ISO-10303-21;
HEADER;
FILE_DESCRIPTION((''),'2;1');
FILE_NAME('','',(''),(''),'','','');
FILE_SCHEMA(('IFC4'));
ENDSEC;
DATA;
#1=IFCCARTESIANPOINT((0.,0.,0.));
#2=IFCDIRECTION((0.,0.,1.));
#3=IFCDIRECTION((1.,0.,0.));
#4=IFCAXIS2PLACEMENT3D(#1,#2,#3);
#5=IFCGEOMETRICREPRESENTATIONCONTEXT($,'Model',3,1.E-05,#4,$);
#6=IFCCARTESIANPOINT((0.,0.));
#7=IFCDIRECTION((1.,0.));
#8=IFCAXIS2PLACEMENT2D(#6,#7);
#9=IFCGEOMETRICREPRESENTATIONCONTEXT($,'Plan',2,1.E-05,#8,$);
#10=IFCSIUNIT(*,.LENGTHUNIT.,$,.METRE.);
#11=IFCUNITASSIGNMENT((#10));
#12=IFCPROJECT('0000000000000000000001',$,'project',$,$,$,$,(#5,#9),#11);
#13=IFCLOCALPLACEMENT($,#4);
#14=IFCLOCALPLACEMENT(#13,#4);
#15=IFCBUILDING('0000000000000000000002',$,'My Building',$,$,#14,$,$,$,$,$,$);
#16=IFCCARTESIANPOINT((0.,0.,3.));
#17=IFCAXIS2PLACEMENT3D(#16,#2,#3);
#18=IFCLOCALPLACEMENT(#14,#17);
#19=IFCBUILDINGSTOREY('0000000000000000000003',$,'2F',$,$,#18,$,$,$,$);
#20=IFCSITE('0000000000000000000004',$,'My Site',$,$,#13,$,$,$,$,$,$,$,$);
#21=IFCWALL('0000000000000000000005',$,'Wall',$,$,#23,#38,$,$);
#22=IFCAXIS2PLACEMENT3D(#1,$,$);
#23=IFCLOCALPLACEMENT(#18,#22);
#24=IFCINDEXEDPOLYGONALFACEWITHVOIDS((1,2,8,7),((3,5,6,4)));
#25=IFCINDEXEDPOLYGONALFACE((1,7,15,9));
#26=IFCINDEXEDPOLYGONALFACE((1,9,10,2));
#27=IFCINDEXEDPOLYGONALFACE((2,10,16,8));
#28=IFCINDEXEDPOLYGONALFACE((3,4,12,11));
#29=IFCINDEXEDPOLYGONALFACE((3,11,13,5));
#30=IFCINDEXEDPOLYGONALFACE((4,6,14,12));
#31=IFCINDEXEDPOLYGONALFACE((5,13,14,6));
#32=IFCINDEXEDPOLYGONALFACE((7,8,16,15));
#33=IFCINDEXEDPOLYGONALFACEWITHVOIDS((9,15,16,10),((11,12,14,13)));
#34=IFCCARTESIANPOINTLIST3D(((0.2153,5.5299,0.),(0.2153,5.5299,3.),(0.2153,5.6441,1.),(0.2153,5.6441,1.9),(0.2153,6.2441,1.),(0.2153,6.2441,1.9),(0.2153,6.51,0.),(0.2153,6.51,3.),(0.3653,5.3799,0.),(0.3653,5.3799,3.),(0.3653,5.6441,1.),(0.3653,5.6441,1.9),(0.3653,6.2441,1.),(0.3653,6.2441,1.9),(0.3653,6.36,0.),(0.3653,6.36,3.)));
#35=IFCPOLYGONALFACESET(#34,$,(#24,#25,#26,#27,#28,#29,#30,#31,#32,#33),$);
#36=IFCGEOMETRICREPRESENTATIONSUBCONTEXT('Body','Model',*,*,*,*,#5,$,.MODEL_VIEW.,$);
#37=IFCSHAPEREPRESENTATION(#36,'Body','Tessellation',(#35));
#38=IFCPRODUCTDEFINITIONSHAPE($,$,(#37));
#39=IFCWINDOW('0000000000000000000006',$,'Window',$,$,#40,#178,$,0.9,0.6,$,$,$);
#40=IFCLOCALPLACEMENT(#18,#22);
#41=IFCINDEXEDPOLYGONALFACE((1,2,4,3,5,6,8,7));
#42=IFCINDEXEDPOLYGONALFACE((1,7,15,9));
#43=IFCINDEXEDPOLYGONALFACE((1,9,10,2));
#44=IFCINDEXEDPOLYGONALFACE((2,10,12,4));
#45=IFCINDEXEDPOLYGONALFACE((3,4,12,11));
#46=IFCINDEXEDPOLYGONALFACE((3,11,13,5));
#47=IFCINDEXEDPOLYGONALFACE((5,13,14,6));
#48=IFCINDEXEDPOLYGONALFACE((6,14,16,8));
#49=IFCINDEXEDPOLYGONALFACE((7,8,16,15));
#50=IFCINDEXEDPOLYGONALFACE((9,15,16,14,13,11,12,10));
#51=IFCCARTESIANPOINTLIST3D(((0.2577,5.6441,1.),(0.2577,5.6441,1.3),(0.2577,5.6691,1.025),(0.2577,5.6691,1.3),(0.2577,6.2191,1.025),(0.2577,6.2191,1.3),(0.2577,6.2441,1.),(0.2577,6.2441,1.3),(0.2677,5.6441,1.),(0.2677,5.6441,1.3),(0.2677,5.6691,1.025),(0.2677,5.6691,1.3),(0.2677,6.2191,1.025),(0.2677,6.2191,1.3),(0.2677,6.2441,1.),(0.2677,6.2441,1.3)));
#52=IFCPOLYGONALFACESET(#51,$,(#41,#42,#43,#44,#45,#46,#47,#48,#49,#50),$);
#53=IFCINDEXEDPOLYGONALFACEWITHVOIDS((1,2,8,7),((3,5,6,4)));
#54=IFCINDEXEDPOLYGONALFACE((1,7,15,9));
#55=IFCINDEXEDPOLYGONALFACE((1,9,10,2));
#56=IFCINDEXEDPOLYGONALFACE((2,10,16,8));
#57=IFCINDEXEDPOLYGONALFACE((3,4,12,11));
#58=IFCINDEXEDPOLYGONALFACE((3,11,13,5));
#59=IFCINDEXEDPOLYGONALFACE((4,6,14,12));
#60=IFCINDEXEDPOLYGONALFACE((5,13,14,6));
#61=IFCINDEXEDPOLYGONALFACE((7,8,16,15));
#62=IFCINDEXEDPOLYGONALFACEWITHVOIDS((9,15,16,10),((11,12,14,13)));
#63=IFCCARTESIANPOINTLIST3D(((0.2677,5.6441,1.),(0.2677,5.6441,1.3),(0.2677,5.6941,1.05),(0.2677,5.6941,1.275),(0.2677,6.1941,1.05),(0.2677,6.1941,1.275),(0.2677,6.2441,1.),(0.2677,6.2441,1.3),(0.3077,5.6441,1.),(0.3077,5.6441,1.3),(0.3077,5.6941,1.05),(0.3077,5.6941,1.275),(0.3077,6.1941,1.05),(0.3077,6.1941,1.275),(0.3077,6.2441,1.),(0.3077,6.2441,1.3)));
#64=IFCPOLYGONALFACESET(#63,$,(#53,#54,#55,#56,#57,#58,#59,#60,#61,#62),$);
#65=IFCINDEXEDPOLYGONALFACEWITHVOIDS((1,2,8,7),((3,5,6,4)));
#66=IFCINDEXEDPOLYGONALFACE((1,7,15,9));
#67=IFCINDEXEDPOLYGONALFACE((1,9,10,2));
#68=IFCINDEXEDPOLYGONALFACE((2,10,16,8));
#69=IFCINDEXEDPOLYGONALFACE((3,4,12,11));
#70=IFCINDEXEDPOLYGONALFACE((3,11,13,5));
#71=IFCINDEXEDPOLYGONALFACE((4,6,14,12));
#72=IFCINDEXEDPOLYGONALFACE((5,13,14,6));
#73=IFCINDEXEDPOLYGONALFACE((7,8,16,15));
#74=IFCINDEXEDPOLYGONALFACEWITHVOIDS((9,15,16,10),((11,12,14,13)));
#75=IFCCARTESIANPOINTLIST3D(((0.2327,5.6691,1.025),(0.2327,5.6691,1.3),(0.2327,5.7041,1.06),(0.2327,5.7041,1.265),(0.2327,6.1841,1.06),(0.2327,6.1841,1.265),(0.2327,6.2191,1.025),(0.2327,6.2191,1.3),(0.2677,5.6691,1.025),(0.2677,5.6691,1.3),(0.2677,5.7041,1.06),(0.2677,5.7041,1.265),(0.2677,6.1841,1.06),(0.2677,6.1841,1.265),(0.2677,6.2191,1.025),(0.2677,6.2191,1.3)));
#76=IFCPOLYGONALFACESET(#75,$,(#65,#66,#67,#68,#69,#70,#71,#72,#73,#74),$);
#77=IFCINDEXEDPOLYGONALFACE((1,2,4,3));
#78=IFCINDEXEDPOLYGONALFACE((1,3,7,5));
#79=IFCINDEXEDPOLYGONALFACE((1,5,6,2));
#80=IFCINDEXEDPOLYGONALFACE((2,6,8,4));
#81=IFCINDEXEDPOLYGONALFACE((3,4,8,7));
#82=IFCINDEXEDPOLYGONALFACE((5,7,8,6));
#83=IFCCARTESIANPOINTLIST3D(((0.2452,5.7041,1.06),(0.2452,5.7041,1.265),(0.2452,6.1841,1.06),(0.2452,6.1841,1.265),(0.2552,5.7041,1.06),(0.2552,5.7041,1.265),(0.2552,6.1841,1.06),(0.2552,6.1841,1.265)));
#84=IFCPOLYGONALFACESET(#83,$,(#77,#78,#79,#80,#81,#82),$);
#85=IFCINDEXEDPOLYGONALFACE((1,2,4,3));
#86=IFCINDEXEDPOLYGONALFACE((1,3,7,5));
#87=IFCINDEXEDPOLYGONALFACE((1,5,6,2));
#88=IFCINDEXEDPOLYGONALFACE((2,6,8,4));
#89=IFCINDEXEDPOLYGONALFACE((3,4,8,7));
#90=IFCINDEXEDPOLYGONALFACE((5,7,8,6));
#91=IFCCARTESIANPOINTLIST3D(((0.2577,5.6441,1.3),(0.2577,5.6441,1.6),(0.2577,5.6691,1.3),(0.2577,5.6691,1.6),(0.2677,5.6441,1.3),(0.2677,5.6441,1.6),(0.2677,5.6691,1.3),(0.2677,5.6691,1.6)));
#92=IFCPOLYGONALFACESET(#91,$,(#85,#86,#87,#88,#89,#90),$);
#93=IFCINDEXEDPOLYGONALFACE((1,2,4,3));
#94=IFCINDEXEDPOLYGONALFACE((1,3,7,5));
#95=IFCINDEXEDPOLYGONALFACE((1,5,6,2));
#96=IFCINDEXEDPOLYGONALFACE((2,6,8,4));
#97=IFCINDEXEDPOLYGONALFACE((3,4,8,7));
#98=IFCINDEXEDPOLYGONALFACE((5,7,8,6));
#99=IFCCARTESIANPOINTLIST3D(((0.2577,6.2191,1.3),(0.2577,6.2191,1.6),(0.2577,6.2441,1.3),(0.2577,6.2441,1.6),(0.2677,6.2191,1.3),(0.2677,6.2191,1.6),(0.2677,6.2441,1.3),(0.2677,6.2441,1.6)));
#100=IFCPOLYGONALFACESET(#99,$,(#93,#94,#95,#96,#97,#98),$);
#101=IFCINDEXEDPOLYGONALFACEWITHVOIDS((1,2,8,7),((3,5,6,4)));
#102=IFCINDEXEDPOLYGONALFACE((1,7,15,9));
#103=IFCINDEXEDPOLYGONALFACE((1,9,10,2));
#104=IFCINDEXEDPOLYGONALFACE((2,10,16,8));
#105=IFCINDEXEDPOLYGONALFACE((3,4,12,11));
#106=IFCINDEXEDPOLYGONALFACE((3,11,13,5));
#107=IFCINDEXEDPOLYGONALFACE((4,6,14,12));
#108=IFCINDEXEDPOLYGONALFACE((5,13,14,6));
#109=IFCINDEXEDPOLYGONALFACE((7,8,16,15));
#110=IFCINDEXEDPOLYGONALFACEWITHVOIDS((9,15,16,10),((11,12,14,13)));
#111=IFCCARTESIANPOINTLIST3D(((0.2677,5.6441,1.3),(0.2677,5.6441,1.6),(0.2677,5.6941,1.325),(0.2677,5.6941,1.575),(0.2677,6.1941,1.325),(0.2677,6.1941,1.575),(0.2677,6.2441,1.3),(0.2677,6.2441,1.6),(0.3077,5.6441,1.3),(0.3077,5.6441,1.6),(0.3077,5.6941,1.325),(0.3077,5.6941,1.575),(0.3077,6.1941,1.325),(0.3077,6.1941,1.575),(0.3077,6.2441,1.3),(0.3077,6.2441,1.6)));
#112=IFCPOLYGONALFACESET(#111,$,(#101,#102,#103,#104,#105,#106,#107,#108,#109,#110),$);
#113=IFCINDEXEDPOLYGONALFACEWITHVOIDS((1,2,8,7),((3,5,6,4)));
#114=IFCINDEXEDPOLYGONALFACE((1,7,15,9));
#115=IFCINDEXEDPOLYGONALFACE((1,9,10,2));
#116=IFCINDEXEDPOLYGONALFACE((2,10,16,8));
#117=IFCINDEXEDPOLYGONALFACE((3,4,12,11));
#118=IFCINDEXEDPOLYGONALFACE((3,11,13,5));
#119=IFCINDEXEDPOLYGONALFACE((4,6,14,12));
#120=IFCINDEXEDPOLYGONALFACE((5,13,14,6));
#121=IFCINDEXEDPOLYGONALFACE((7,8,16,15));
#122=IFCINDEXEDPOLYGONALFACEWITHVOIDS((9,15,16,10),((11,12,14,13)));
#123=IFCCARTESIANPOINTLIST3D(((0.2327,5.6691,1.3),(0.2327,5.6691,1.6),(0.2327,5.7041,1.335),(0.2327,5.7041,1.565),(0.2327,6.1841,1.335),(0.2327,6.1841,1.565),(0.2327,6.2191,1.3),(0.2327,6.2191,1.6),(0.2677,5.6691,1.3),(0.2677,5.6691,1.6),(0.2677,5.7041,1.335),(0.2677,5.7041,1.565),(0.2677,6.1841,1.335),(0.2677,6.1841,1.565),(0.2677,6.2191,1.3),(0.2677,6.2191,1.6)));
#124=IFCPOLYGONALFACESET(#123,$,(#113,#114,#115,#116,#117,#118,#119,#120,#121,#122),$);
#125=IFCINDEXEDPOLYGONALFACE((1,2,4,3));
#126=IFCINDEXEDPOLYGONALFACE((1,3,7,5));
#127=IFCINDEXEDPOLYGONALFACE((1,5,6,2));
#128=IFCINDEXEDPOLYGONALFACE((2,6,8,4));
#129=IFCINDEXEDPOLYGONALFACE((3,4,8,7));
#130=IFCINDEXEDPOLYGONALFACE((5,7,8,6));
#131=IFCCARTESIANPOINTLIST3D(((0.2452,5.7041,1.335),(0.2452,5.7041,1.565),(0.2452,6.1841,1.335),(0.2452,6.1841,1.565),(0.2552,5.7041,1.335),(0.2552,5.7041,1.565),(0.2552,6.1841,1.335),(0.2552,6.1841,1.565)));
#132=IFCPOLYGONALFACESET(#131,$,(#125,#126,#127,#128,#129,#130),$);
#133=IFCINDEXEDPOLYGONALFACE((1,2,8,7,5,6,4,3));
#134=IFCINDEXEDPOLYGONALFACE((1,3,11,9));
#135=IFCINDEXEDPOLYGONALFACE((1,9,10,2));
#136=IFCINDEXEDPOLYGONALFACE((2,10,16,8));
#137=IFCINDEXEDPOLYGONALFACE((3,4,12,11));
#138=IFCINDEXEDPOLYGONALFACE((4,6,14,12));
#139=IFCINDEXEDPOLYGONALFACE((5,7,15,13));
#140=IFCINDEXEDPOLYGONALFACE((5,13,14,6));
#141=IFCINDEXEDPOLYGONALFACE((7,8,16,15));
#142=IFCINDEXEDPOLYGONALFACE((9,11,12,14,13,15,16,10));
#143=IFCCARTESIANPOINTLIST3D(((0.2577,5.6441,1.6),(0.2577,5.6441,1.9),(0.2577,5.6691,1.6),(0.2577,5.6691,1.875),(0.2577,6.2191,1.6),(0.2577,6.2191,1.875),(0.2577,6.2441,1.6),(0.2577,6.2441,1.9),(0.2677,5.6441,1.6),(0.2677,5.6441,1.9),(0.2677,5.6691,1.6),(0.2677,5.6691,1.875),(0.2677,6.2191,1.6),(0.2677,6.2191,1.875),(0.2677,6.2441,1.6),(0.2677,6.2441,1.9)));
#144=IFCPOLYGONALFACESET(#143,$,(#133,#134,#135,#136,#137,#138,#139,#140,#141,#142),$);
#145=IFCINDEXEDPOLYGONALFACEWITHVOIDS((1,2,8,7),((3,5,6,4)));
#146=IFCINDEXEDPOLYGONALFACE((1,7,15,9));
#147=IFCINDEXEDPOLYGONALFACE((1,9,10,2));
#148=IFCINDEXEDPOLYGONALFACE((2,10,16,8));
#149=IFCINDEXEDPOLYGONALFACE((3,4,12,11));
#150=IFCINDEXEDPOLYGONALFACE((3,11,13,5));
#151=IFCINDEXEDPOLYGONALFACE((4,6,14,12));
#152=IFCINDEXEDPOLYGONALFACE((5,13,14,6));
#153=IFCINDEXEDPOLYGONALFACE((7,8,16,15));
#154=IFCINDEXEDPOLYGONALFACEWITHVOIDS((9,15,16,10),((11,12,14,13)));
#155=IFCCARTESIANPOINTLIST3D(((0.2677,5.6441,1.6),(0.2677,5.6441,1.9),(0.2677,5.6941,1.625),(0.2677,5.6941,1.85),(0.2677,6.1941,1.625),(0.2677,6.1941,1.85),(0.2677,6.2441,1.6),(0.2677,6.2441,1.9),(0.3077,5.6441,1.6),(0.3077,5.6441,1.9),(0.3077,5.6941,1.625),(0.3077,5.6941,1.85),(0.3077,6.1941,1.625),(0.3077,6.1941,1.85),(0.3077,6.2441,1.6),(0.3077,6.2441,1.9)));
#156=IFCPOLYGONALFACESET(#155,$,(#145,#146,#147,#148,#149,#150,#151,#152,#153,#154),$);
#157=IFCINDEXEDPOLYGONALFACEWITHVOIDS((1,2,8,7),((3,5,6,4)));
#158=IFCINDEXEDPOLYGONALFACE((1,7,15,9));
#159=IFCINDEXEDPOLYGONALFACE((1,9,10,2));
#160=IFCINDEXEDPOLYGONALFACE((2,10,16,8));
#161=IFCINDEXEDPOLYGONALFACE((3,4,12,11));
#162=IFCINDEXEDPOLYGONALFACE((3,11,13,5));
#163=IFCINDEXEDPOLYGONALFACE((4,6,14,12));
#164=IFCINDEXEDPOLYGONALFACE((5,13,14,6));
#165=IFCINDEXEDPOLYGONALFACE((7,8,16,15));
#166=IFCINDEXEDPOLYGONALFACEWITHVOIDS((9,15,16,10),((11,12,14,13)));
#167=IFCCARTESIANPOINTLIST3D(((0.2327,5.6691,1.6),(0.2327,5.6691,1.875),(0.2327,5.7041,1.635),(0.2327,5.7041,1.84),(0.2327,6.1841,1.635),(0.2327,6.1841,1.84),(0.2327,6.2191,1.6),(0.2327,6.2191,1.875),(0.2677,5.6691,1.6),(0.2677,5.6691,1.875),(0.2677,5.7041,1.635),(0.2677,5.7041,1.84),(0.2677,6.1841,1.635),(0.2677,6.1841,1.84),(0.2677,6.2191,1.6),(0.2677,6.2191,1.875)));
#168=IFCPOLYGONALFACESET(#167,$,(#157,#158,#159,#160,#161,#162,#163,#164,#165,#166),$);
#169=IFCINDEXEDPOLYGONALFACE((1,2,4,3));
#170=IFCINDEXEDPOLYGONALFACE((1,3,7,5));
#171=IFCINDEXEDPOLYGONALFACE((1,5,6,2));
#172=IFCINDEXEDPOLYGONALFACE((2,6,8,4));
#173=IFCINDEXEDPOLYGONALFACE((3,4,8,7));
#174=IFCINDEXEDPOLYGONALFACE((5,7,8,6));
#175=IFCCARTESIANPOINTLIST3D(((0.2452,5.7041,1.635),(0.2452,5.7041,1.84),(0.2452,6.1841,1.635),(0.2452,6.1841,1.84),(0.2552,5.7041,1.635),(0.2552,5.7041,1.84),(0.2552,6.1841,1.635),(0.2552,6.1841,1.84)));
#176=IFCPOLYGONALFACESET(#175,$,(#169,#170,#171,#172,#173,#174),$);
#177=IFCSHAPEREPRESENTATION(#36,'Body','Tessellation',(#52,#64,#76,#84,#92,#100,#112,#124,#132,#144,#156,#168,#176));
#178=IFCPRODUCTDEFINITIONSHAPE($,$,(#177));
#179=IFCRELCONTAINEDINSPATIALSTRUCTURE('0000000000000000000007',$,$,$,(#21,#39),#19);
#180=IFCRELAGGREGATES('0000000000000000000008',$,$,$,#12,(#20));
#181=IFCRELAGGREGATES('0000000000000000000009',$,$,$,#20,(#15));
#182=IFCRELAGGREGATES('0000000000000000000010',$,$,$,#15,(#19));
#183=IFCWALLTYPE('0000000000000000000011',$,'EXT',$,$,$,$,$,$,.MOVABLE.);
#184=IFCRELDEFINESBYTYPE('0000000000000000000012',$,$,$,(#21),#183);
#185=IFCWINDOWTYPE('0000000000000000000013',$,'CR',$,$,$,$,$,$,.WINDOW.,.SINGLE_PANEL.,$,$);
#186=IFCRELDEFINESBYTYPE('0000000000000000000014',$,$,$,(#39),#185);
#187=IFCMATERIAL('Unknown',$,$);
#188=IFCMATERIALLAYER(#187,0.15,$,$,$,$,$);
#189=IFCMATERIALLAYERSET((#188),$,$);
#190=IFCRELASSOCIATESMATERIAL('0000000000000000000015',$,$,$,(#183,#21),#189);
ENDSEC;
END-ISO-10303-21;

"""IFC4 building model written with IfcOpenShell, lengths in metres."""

from ifc_helpers import new_model, entity, si_unit, frame, origin_with_axes, origin_2d_with_axis, place, context, subcontext, project, spatial, line, indexed_curve, outline, extrude, shape, source, transform, mapped, material, layer, layer_set, layer_usage, type_object, type_shapes, element, fill, save


model = new_model("IFC4")

# Units and contexts
model_context = context("Model", 3, precision=1e-05, world=origin_with_axes())
plan_context = context("Plan", 2, precision=1e-05, world=origin_2d_with_axis())
body_context_1 = subcontext(model_context, "Body", "Model", "MODEL_VIEW")
body_context_2 = subcontext(plan_context, "Body", "Plan", "PLAN_VIEW")
ifc_project = project(units=[si_unit("LENGTHUNIT", "METRE")], contexts=[model_context, plan_context])

# Site, building, storey
site_placement = place(None, origin_with_axes())
site = spatial("IfcSite", under=ifc_project, at=site_placement, Name="My Site")
building_placement = place(site_placement, origin_with_axes())
building = spatial("IfcBuilding", under=site, at=building_placement, Name="My Building")
storey_placement = place(building_placement, frame((0.0, 0.0, 3.0), z_axis=(0.0, 0.0, 1.0), x_axis=(1.0, 0.0, 0.0)))
storey = spatial("IfcBuildingStorey", under=building, at=storey_placement, Name="2F")

# Shared definitions
ifc_material = material(Name="Unknown")

# Shared definitions
ifc_layer_1 = layer(ifc_material, 0.15)
ifc_layer_set_1 = layer_set([ifc_layer_1])
wall_type_1 = type_object("IfcWallType", Name="EXT", PredefinedType="MOVABLE", material=ifc_layer_set_1)

# Wall, opening, window
ifc_layer_usage_1 = layer_usage(ifc_layer_set_1, "AXIS2", "POSITIVE", -0.15)
wall_1_placement = place(storey_placement, frame((0.2153, 5.5299, 0.0), z_axis=(0.0, 0.0, 1.0), x_axis=(0.0, 1.0, 0.0)))
wall_1 = element("IfcWall", 1, at=wall_1_placement, inside=storey, type_object=wall_type_1, material=ifc_layer_usage_1, Name="Wall", context=body_context_1, shape_type="SweptSolid", body=[
    extrude(outline(indexed_curve([(-0.15, -0.15), (0.0, 0.0), (0.9801, 0.0), (0.8301, -0.15)], segments=[line(1, 2, 3, 4, 1)])), origin_with_axes(), (0.0, 0.0, 1.0), 3.0),
])
placement_1 = place(storey_placement, frame((0.3577, 5.6441, 1.0), z_axis=(0.0, 0.0, 1.0), x_axis=(0.0, 1.0, 0.0)))
opening_1 = element("IfcOpeningElement", 2, at=placement_1, cuts=wall_1, PredefinedType="OPENING", context=body_context_1, shape_type="SweptSolid", body=[
    extrude(outline(indexed_curve([(0.0, 0.0), (0.6, 0.0), (0.6, 0.9), (0.0, 0.9)], segments=[line(1, 2, 3, 4, 1)])), frame((0.0, -0.6, 0.0), z_axis=(0.0, -1.0, 0.0), x_axis=(1.0, 0.0, 0.0)), (0.0, 0.0, -1.0), 1.2),
])
window_type_1 = type_object("IfcWindowType", Name="CR", PartitioningType="SINGLE_PANEL", PredefinedType="WINDOW")
shared_shape_1 = source(origin_with_axes(), body_context_1, "Body", "SweptSolid", [
    extrude(outline(indexed_curve([(0.6, 0.3), (0.6, 0.0), (0.0, 0.0), (0.0, 0.3), (0.025, 0.3), (0.025, 0.025), (0.575, 0.025), (0.575, 0.3)], segments=[line(1, 2, 3, 4, 5, 6, 7, 8, 1)])), frame((0.0, 0.09, 0.0), z_axis=(0.0, -1.0, 0.0), x_axis=(1.0, 0.0, 0.0)), (0.0, 0.0, -1.0), 0.01),
    extrude(outline(indexed_curve([(0.0, 0.0), (0.6, 0.0), (0.6, 0.3), (0.0, 0.3)], segments=[line(1, 2, 3, 4, 1)]), holes=[indexed_curve([(0.05, 0.05), (0.55, 0.05), (0.55, 0.275), (0.05, 0.275)], segments=[line(1, 2, 3, 4, 1)])]), frame((0.0, 0.05, 0.0), z_axis=(0.0, -1.0, 0.0), x_axis=(1.0, 0.0, 0.0)), (0.0, 0.0, -1.0), 0.04),
    extrude(outline(indexed_curve([(0.0, 0.0), (0.55, 0.0), (0.55, 0.275), (0.0, 0.275)], segments=[line(1, 2, 3, 4, 1)]), holes=[indexed_curve([(0.035, 0.035), (0.515, 0.035), (0.515, 0.24), (0.035, 0.24)], segments=[line(1, 2, 3, 4, 1)])]), frame((0.025, 0.09, 0.025), z_axis=(0.0, -1.0, 0.0), x_axis=(1.0, 0.0, 0.0)), (0.0, 0.0, -1.0), 0.035),
    extrude(outline(indexed_curve([(0.035, 0.035), (0.515, 0.035), (0.515, 0.24), (0.035, 0.24)], segments=[line(1, 2, 3, 4, 1)])), frame((0.025, 0.1025, 0.025), z_axis=(0.0, -1.0, 0.0), x_axis=(1.0, 0.0, 0.0)), (0.0, 0.0, -1.0), 0.01),
    extrude(outline(indexed_curve([(0.0, 0.0), (0.0, 0.3), (0.025, 0.3), (0.025, 0.0)], segments=[line(1, 2, 3, 4, 1)])), frame((0.0, 0.09, 0.3), z_axis=(0.0, -1.0, 0.0), x_axis=(1.0, 0.0, 0.0)), (0.0, 0.0, -1.0), 0.01),
    extrude(outline(indexed_curve([(0.6, 0.3), (0.6, 0.0), (0.575, 0.0), (0.575, 0.3)], segments=[line(1, 2, 3, 4, 1)])), frame((0.0, 0.09, 0.3), z_axis=(0.0, -1.0, 0.0), x_axis=(1.0, 0.0, 0.0)), (0.0, 0.0, -1.0), 0.01),
    extrude(outline(indexed_curve([(0.0, 0.0), (0.6, 0.0), (0.6, 0.3), (0.0, 0.3)], segments=[line(1, 2, 3, 4, 1)]), holes=[indexed_curve([(0.05, 0.025), (0.55, 0.025), (0.55, 0.275), (0.05, 0.275)], segments=[line(1, 2, 3, 4, 1)])]), frame((0.0, 0.05, 0.3), z_axis=(0.0, -1.0, 0.0), x_axis=(1.0, 0.0, 0.0)), (0.0, 0.0, -1.0), 0.04),
    extrude(outline(indexed_curve([(0.0, 0.0), (0.55, 0.0), (0.55, 0.3), (0.0, 0.3)], segments=[line(1, 2, 3, 4, 1)]), holes=[indexed_curve([(0.035, 0.035), (0.515, 0.035), (0.515, 0.265), (0.035, 0.265)], segments=[line(1, 2, 3, 4, 1)])]), frame((0.025, 0.09, 0.3), z_axis=(0.0, -1.0, 0.0), x_axis=(1.0, 0.0, 0.0)), (0.0, 0.0, -1.0), 0.035),
    extrude(outline(indexed_curve([(0.035, 0.035), (0.515, 0.035), (0.515, 0.265), (0.035, 0.265)], segments=[line(1, 2, 3, 4, 1)])), frame((0.025, 0.1025, 0.3), z_axis=(0.0, -1.0, 0.0), x_axis=(1.0, 0.0, 0.0)), (0.0, 0.0, -1.0), 0.01),
    extrude(outline(indexed_curve([(0.0, 0.0), (0.0, 0.3), (0.6, 0.3), (0.6, 0.0), (0.575, 0.0), (0.575, 0.275), (0.025, 0.275), (0.025, 0.0)], segments=[line(1, 2, 3, 4, 5, 6, 7, 8, 1)])), frame((0.0, 0.09, 0.6), z_axis=(0.0, -1.0, 0.0), x_axis=(1.0, 0.0, 0.0)), (0.0, 0.0, -1.0), 0.01),
    extrude(outline(indexed_curve([(0.0, 0.0), (0.6, 0.0), (0.6, 0.3), (0.0, 0.3)], segments=[line(1, 2, 3, 4, 1)]), holes=[indexed_curve([(0.05, 0.025), (0.55, 0.025), (0.55, 0.25), (0.05, 0.25)], segments=[line(1, 2, 3, 4, 1)])]), frame((0.0, 0.05, 0.6), z_axis=(0.0, -1.0, 0.0), x_axis=(1.0, 0.0, 0.0)), (0.0, 0.0, -1.0), 0.04),
    extrude(outline(indexed_curve([(0.0, 0.0), (0.55, 0.0), (0.55, 0.275), (0.0, 0.275)], segments=[line(1, 2, 3, 4, 1)]), holes=[indexed_curve([(0.035, 0.035), (0.515, 0.035), (0.515, 0.24), (0.035, 0.24)], segments=[line(1, 2, 3, 4, 1)])]), frame((0.025, 0.09, 0.6), z_axis=(0.0, -1.0, 0.0), x_axis=(1.0, 0.0, 0.0)), (0.0, 0.0, -1.0), 0.035),
    extrude(outline(indexed_curve([(0.035, 0.035), (0.515, 0.035), (0.515, 0.24), (0.035, 0.24)], segments=[line(1, 2, 3, 4, 1)])), frame((0.025, 0.1025, 0.6), z_axis=(0.0, -1.0, 0.0), x_axis=(1.0, 0.0, 0.0)), (0.0, 0.0, -1.0), 0.01),
])
shared_shape_2 = source(origin_with_axes(), body_context_2, "Body", "Curve2D", [
    entity("IfcIndexedPolyCurve", entity("IfcCartesianPointList2D", [[0.05, 0.05], [0.55, 0.05]])),
    entity("IfcIndexedPolyCurve", entity("IfcCartesianPointList2D", [[0.0, 0.1], [0.025, 0.1], [0.025, 0.09], [0.05, 0.09], [0.05, 0.05], [0.0, 0.05]]), [entity("IfcLineIndex", [1, 2, 3, 4, 5, 6, 1])]),
    entity("IfcIndexedPolyCurve", entity("IfcCartesianPointList2D", [[0.6, 0.1], [0.575, 0.1], [0.575, 0.09], [0.55, 0.09], [0.55, 0.05], [0.6, 0.05]]), [entity("IfcLineIndex", [1, 2, 3, 4, 5, 6, 1])]),
    entity("IfcIndexedPolyCurve", entity("IfcCartesianPointList2D", [[0.025, 0.09], [0.06, 0.09], [0.06, 0.125], [0.025, 0.125]]), [entity("IfcLineIndex", [1, 2, 3, 4, 1])]),
    entity("IfcIndexedPolyCurve", entity("IfcCartesianPointList2D", [[0.575, 0.09], [0.54, 0.09], [0.54, 0.125], [0.575, 0.125]]), [entity("IfcLineIndex", [1, 2, 3, 4, 1])]),
    entity("IfcIndexedPolyCurve", entity("IfcCartesianPointList2D", [[0.06, 0.09], [0.54, 0.09]])),
    entity("IfcIndexedPolyCurve", entity("IfcCartesianPointList2D", [[0.06, 0.125], [0.54, 0.125]])),
    entity("IfcIndexedPolyCurve", entity("IfcCartesianPointList2D", [[0.06, 0.1075], [0.54, 0.1075]])),
])
type_shapes(window_type_1, [shared_shape_1, shared_shape_2])
window_1 = element("IfcWindow", 3, at=placement_1, inside=storey, type_object=window_type_1, Name="Window", OverallHeight=0.9, OverallWidth=0.6, shapes=[
    shape(body_context_1, "Body", "MappedRepresentation", [mapped(shared_shape_1, transform((0.0, 0.0, 0.0), x_axis=(1.0, 0.0, 0.0), y_axis=(0.0, 1.0, 0.0), z_axis=(0.0, 0.0, 1.0), scale=1.0))]),
    shape(body_context_2, "Body", "MappedRepresentation", [mapped(shared_shape_2, transform((0.0, 0.0, 0.0), x_axis=(1.0, 0.0, 0.0), y_axis=(0.0, 1.0, 0.0), z_axis=(0.0, 0.0, 1.0), scale=1.0))]),
])
fill(opening_1, window_1)

save(model, "model.ifc")
